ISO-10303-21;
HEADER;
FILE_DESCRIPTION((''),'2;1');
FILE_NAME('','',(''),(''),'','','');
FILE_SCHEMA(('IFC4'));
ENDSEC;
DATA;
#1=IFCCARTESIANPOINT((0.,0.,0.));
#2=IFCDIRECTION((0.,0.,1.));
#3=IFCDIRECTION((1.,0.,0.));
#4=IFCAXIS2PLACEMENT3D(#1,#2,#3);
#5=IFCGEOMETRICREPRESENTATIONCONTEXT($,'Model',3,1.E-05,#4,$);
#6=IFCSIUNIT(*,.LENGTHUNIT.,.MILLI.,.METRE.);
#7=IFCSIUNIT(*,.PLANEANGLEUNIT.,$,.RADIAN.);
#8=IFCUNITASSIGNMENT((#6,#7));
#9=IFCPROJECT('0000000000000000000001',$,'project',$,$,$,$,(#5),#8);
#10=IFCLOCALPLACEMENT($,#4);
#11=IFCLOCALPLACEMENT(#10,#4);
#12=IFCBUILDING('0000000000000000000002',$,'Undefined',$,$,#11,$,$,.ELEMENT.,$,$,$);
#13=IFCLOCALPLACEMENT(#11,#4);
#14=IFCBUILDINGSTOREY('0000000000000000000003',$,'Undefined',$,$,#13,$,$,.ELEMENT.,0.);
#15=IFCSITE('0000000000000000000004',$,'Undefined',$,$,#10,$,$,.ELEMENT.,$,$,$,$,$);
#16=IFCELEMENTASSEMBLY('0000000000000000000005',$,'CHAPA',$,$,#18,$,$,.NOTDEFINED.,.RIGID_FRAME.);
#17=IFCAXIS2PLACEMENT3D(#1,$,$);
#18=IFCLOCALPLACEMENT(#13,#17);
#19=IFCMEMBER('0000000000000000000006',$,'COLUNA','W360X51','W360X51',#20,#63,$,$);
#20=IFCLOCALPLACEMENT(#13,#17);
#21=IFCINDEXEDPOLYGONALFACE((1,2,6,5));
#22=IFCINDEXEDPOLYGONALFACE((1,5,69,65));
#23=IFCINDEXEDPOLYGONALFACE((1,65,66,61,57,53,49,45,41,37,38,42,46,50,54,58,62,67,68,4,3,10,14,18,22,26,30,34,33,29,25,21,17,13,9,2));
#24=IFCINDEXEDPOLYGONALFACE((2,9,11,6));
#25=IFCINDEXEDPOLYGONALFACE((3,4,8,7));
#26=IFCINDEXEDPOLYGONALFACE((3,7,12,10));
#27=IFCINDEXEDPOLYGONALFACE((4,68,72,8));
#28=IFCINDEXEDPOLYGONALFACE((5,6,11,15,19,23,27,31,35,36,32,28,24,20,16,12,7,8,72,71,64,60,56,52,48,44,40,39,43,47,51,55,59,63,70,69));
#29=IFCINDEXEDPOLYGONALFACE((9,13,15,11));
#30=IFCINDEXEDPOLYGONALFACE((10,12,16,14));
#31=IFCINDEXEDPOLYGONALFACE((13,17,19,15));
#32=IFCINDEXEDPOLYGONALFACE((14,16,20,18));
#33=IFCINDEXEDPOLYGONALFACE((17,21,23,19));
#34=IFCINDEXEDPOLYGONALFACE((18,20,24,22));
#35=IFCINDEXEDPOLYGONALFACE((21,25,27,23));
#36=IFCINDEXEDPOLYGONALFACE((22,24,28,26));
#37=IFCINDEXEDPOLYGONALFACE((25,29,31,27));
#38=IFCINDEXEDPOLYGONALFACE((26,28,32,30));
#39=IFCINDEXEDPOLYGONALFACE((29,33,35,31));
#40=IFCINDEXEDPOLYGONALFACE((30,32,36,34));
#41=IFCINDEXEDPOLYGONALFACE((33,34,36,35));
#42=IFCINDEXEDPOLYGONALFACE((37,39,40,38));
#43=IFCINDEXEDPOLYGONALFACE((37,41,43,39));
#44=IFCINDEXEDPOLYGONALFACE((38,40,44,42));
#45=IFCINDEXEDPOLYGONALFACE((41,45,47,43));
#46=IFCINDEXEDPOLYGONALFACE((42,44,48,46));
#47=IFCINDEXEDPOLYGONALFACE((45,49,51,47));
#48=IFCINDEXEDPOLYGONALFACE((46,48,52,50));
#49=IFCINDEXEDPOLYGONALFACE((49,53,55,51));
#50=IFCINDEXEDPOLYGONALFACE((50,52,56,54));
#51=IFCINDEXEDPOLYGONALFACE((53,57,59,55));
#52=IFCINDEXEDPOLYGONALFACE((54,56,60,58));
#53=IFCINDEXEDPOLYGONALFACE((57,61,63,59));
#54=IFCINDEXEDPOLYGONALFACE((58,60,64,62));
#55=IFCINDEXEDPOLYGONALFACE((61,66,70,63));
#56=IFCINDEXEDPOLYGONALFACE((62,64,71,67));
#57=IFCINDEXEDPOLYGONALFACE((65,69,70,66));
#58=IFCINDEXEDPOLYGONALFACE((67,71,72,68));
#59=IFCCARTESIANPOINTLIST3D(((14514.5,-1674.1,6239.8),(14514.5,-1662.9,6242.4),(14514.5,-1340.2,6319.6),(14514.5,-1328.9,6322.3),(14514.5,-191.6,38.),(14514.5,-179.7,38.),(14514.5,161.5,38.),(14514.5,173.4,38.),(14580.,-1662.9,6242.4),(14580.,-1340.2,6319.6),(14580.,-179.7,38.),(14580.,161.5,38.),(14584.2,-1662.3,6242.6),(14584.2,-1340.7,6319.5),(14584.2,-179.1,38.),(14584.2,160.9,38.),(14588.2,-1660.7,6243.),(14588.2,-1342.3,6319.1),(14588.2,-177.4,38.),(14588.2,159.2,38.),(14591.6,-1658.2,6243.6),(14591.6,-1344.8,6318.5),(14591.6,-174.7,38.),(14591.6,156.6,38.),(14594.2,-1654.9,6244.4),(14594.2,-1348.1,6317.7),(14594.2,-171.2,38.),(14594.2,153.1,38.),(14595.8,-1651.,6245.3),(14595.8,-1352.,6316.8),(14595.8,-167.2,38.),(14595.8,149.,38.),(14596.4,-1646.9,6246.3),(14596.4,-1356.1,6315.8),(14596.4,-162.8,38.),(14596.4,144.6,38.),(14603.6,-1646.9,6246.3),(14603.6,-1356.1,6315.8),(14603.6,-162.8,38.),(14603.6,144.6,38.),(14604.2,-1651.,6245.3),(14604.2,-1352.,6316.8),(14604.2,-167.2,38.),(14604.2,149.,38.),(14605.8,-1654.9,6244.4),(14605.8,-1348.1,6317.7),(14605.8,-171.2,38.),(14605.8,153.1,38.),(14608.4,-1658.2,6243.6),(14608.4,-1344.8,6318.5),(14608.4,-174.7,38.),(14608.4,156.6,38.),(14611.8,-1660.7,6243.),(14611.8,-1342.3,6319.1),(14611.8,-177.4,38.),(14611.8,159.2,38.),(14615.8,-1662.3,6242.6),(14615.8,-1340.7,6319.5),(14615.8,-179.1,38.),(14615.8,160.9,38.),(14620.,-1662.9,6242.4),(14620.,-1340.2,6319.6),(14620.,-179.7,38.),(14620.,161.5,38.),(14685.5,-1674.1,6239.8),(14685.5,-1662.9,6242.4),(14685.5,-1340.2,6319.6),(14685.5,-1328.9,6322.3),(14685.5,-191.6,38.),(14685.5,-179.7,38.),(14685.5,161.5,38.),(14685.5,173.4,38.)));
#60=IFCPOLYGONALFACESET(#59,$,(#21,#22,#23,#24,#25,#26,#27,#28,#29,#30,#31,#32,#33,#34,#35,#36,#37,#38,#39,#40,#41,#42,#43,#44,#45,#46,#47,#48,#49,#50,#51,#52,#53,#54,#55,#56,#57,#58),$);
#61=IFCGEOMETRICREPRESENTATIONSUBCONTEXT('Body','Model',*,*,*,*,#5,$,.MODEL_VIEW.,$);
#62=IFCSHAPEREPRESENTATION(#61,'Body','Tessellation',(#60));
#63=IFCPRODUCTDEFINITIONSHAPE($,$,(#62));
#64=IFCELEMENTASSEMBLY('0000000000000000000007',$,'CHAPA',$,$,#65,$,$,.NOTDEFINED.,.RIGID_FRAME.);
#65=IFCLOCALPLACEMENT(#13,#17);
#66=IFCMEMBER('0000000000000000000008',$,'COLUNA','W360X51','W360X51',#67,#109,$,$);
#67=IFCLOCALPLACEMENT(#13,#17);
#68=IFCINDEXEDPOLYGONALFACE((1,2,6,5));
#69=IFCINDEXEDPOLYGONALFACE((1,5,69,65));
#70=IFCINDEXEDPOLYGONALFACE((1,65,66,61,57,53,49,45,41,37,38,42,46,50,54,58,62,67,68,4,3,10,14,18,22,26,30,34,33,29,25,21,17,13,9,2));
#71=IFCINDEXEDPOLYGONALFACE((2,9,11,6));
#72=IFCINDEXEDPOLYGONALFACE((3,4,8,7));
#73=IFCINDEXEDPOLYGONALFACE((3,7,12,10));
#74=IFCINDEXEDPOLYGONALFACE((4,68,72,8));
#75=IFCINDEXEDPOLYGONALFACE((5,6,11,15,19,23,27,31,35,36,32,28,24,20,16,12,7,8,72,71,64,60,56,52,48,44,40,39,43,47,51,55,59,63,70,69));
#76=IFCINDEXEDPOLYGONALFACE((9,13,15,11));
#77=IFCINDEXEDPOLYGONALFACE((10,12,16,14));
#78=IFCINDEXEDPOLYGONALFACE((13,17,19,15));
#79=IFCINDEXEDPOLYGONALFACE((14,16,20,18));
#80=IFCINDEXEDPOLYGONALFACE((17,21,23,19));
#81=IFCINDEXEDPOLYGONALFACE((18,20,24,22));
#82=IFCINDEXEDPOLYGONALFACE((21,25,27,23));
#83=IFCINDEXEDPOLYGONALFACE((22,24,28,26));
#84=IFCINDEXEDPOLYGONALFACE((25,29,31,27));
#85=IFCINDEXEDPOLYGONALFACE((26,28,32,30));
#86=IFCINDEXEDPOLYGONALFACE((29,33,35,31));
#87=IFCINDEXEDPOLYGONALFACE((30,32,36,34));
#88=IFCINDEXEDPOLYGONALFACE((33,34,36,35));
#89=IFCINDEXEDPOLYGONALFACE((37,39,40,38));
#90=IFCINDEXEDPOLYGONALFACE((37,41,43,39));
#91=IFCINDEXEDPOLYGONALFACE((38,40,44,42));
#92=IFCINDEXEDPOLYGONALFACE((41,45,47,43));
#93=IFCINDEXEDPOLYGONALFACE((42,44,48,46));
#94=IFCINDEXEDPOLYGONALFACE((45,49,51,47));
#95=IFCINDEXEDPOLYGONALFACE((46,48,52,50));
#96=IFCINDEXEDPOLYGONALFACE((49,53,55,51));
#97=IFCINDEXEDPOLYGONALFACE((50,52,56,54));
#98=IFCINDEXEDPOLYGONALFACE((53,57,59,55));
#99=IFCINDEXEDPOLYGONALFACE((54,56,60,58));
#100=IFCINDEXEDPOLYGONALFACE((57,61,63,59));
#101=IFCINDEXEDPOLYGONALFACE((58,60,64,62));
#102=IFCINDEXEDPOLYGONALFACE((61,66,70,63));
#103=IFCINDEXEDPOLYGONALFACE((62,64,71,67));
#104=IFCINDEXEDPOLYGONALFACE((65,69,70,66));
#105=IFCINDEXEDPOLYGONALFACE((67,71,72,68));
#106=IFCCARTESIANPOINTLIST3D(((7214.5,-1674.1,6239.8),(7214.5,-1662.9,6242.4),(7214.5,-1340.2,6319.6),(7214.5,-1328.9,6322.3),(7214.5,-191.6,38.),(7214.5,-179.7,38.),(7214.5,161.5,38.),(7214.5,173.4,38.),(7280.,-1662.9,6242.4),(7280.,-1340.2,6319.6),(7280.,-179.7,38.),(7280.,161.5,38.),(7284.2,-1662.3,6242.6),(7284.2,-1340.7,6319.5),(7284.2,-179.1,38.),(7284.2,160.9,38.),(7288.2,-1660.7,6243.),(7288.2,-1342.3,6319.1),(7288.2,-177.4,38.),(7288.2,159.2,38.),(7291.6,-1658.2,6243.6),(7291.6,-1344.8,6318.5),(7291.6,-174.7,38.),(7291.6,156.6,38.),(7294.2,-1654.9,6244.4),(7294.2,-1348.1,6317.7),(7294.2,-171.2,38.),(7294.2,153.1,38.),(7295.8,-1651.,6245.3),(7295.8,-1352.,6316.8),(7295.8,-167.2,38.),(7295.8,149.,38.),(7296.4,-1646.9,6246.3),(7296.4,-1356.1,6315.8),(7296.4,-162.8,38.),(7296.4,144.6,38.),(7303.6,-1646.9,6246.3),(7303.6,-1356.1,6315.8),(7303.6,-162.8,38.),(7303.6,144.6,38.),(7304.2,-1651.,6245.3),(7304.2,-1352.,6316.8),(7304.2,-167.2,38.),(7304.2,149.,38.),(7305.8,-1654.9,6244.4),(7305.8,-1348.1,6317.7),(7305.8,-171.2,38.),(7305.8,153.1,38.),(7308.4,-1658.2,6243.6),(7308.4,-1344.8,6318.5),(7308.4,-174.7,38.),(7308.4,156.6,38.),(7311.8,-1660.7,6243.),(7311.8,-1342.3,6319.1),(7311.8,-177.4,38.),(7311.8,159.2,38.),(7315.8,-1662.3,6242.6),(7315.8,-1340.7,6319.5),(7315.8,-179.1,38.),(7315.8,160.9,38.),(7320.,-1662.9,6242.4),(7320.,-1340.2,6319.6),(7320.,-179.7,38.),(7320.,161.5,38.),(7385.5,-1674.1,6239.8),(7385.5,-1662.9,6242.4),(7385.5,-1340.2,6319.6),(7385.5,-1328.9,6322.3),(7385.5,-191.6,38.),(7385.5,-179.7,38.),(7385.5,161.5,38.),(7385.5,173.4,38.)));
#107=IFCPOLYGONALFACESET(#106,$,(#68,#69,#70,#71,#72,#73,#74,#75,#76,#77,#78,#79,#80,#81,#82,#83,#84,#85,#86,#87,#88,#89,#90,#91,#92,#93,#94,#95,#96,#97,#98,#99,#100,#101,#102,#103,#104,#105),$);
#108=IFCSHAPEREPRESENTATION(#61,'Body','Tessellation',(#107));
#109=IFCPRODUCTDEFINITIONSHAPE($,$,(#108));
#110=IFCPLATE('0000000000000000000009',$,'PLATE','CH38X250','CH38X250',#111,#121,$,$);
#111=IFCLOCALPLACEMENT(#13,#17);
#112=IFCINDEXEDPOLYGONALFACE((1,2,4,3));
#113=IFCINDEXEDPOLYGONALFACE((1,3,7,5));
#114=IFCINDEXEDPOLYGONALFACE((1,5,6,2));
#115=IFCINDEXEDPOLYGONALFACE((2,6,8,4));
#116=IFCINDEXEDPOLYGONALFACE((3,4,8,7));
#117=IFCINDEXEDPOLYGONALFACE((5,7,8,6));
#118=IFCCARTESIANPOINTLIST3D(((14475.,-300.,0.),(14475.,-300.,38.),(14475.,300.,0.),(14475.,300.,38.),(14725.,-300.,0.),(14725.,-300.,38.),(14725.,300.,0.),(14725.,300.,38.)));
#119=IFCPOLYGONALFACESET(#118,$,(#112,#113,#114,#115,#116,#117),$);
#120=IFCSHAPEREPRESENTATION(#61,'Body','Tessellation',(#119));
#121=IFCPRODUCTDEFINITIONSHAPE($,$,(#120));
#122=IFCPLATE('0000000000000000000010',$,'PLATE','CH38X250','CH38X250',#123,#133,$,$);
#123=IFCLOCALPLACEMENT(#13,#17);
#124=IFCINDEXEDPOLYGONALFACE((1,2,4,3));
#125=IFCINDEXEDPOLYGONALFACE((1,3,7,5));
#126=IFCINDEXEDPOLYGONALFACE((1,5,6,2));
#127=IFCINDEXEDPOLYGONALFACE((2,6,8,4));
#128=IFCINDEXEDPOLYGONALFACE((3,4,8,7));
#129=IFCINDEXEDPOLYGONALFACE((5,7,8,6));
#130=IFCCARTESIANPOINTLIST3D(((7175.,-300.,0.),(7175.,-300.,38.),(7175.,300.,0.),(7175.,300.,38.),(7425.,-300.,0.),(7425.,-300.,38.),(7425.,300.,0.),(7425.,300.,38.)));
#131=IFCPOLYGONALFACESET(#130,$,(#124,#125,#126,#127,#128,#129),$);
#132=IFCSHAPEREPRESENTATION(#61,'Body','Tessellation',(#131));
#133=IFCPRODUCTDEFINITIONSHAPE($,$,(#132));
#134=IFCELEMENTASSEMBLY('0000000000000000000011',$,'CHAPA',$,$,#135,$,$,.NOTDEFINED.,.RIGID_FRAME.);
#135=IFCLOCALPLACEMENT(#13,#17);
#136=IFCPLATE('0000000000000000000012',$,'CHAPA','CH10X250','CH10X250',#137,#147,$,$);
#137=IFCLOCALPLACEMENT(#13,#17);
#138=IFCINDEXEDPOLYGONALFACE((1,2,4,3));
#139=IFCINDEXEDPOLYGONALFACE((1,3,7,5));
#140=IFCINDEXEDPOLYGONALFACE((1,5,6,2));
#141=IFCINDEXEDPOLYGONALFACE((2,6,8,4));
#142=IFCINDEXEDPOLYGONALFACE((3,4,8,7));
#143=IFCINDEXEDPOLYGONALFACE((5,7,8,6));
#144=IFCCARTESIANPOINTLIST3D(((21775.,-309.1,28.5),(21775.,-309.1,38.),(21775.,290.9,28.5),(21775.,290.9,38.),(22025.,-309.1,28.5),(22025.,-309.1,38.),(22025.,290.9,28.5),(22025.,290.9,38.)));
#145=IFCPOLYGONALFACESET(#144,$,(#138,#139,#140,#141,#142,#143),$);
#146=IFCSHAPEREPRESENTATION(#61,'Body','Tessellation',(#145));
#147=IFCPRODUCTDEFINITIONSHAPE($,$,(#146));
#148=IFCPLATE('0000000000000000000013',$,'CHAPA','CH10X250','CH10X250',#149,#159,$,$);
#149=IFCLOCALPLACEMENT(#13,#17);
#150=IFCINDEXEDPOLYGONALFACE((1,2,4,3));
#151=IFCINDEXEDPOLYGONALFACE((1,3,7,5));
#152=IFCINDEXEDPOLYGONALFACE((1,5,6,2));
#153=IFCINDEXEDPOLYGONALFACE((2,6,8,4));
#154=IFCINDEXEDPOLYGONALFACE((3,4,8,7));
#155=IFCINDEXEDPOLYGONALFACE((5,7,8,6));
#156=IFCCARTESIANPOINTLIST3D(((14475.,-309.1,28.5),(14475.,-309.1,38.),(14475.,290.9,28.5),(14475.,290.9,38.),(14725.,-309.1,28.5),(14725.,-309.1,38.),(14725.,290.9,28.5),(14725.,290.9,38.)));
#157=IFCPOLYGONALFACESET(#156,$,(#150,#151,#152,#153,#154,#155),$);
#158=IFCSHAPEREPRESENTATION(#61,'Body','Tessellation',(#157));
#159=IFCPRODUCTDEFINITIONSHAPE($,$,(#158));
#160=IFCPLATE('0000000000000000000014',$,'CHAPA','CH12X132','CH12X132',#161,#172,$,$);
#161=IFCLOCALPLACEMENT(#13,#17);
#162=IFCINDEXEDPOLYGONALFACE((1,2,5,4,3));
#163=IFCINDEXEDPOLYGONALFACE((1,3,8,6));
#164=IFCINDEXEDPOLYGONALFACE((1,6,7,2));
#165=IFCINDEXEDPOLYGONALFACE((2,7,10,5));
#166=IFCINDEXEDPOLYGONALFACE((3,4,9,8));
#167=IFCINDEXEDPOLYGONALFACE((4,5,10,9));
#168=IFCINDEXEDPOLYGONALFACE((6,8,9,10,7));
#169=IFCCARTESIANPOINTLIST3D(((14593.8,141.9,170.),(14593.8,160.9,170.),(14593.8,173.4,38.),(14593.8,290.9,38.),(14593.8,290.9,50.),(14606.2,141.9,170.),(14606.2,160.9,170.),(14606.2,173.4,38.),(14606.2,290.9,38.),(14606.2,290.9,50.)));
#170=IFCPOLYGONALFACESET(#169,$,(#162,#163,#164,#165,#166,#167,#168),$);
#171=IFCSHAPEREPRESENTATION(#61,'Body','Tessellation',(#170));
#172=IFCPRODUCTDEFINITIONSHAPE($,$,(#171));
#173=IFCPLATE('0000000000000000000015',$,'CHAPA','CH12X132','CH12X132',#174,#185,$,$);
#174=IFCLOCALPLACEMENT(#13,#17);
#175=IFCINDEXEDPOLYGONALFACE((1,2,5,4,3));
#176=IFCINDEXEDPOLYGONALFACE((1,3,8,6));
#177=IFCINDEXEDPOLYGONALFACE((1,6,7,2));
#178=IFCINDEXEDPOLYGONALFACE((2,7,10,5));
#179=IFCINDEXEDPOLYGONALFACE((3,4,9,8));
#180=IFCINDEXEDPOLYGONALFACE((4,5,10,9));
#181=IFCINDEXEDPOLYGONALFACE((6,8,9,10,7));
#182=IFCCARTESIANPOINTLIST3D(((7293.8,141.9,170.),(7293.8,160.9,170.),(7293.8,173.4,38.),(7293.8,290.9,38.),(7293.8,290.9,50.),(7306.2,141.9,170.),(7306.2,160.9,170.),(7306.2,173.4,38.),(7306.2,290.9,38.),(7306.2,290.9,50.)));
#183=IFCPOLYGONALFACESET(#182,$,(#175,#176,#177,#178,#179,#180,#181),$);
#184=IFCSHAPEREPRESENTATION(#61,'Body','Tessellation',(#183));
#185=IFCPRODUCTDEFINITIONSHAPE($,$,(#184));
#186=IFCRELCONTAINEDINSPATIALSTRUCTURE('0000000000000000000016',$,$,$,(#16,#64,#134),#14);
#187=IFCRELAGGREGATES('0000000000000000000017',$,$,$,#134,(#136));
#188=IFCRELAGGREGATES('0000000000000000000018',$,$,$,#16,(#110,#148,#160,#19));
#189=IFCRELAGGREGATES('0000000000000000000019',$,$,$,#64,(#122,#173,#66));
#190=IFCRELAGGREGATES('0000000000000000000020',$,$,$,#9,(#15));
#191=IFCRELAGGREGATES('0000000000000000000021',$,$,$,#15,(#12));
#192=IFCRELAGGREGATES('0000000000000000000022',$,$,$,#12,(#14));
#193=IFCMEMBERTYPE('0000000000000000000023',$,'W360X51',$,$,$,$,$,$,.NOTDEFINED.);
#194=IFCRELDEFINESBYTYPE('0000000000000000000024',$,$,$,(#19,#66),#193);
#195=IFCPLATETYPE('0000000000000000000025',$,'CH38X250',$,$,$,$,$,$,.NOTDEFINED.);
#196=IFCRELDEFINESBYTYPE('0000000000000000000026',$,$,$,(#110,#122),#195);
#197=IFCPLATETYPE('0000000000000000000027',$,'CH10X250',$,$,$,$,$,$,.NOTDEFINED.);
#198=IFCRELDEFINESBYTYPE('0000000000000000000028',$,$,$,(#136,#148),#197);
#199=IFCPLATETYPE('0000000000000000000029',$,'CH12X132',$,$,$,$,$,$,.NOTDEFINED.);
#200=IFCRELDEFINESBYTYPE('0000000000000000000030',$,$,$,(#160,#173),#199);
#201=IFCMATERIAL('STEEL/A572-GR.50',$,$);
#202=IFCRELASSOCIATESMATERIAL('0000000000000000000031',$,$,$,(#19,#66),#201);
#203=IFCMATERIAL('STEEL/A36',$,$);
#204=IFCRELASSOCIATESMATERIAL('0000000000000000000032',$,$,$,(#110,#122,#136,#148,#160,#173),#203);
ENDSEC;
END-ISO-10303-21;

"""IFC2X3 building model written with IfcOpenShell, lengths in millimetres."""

from ifc_helpers import new_model, si_unit, frame, origin_with_axes, origin_2d_with_axis, place, context, subcontext, project, spatial, polyline, i_section, outline, extrude, clip, halfspace, material, type_object, element, aggregate, save


model = new_model("IFC2X3")

# Units and contexts
model_context = context("Model", 3, precision=1e-05, world=origin_with_axes())
body_context = subcontext(model_context, "Body", "Model", "MODEL_VIEW")
ifc_project = project(units=[si_unit("LENGTHUNIT", "METRE", prefix="MILLI"), si_unit("PLANEANGLEUNIT", "RADIAN")], contexts=[model_context])

# Site, building, storey
site_placement = place(None, origin_with_axes())
site = spatial("IfcSite", under=ifc_project, at=site_placement, Name="Undefined", CompositionType="ELEMENT")
building_placement = place(site_placement, origin_with_axes())
building = spatial("IfcBuilding", under=site, at=building_placement, Name="Undefined", CompositionType="ELEMENT")
storey_placement = place(building_placement, origin_with_axes())
storey = spatial("IfcBuildingStorey", under=building, at=storey_placement, Name="Undefined", CompositionType="ELEMENT", Elevation=0.0)

# Element assemblies, members
assembly_1_placement = place(storey_placement, origin_with_axes())
assembly_1 = element("IfcElementAssembly", 1, at=assembly_1_placement, inside=storey, Name="CHAPA", AssemblyPlace="NOTDEFINED", PredefinedType="RIGID_FRAME")
ifc_material_1 = material(Name="STEEL/A572-GR.50")
member_type = type_object("IfcMemberType", Name="W360X51", PredefinedType="NOTDEFINED")
member_1_placement = place(assembly_1_placement, frame((14600.0, 23.3, -97.3), z_axis=(0.0, -0.972595, -0.232504), x_axis=(0.0, -0.232504, 0.972595)))
member_1 = element("IfcMember", 2, at=member_1_placement, type_object=member_type, material=ifc_material_1, Name="COLUNA", Description="W360X51", ObjectType="W360X51", context=body_context, shape_type="Clipping", body=[
    clip(clip(extrude(i_section(OverallWidth=171.0, OverallDepth=355.0, WebThickness=7.2, FlangeThickness=11.6, FilletRadius=16.4, at=origin_2d_with_axis()), frame((6558.0, 0.0, 0.0), z_axis=(-1.0, 0.0, 0.0), x_axis=(0.0, -1.0, 0.0)), (0.0, 0.0, 1.0), 6542.9), halfspace(frame((94.5, 85.5, -186.3), z_axis=(-0.972595, 0.0, 0.232504), x_axis=(0.232504, 0.0, 0.972595)), False)), halfspace(frame((96.6, 0.0, -177.5), z_axis=(0.972595, 0.0, -0.232504), x_axis=(0.0, -1.0, 0.0)), True)),
])
assembly_2_placement = place(storey_placement, origin_with_axes())
assembly_2 = element("IfcElementAssembly", 3, at=assembly_2_placement, inside=storey, Name="CHAPA", AssemblyPlace="NOTDEFINED", PredefinedType="RIGID_FRAME")
member_2_placement = place(assembly_2_placement, frame((7300.0, 23.3, -97.3), z_axis=(0.0, -0.972595, -0.232504), x_axis=(0.0, -0.232504, 0.972595)))
member_2 = element("IfcMember", 4, at=member_2_placement, type_object=member_type, material=ifc_material_1, Name="COLUNA", Description="W360X51", ObjectType="W360X51", context=body_context, shape_type="Clipping", body=[
    clip(clip(extrude(i_section(OverallWidth=171.0, OverallDepth=355.0, WebThickness=7.2, FlangeThickness=11.6, FilletRadius=16.4, at=origin_2d_with_axis()), frame((6558.0, 0.0, 0.0), z_axis=(-1.0, 0.0, 0.0), x_axis=(0.0, -1.0, 0.0)), (0.0, 0.0, 1.0), 6542.9), halfspace(frame((94.5, 85.5, -186.3), z_axis=(-0.972595, 0.0, 0.232504), x_axis=(0.232504, 0.0, 0.972595)), False)), halfspace(frame((96.6, 0.0, -177.5), z_axis=(0.972595, 0.0, -0.232504), x_axis=(0.0, -1.0, 0.0)), True)),
])

# Plates
ifc_material_2 = material(Name="STEEL/A36")
plate_type_1 = type_object("IfcPlateType", Name="CH38X250", PredefinedType="NOTDEFINED")
plate_1_placement = place(assembly_1_placement, frame((14725.0, -300.0, 19.0), z_axis=(0.0, 0.0, 1.0), x_axis=(0.0, 1.0, 0.0)))
plate_1 = element("IfcPlate", 5, at=plate_1_placement, type_object=plate_type_1, material=ifc_material_2, Name="PLATE", Description="CH38X250", ObjectType="CH38X250", context=body_context, shape_type="SweptSolid", body=[
    extrude(outline(polyline([(0.0, 0.0), (600.0, 0.0), (600.0, 250.0), (0.0, 250.0), (0.0, 0.0)])), frame((0.0, 0.0, -19.0), z_axis=(0.0, 0.0, 1.0), x_axis=(1.0, 0.0, 0.0)), (0.0, 0.0, 1.0), 38.0),
])
plate_2_placement = place(assembly_2_placement, frame((7425.0, -300.0, 19.0), z_axis=(0.0, 0.0, 1.0), x_axis=(0.0, 1.0, 0.0)))
plate_2 = element("IfcPlate", 6, at=plate_2_placement, type_object=plate_type_1, material=ifc_material_2, Name="PLATE", Description="CH38X250", ObjectType="CH38X250", context=body_context, shape_type="SweptSolid", body=[
    extrude(outline(polyline([(0.0, 0.0), (600.0, 0.0), (600.0, 250.0), (0.0, 250.0), (0.0, 0.0)])), frame((0.0, 0.0, -19.0), z_axis=(0.0, 0.0, 1.0), x_axis=(1.0, 0.0, 0.0)), (0.0, 0.0, 1.0), 38.0),
])

# Element assembly, plate
assembly_3_placement = place(storey_placement, origin_with_axes())
assembly_3 = element("IfcElementAssembly", 7, at=assembly_3_placement, inside=storey, Name="CHAPA", AssemblyPlace="NOTDEFINED", PredefinedType="RIGID_FRAME")
plate_type_2 = type_object("IfcPlateType", Name="CH10X250", PredefinedType="NOTDEFINED")
plate_3_placement = place(assembly_3_placement, frame((21775.0, -309.1, 33.2), z_axis=(0.0, 0.0, 1.0), x_axis=(1.0, 0.0, 0.0)))
plate_3 = element("IfcPlate", 8, at=plate_3_placement, type_object=plate_type_2, material=ifc_material_2, Name="CHAPA", Description="CH10X250", ObjectType="CH10X250", context=body_context, shape_type="SweptSolid", body=[
    extrude(outline(polyline([(0.0, 0.0), (250.0, 0.0), (250.0, 600.0), (0.0, 600.0), (0.0, 0.0)])), frame((0.0, 0.0, -4.8), z_axis=(0.0, 0.0, 1.0), x_axis=(1.0, 0.0, 0.0)), (0.0, 0.0, 1.0), 9.5),
])
aggregate(assembly_3, [plate_3])

# Plates
plate_4_placement = place(assembly_1_placement, frame((14475.0, -309.1, 33.2), z_axis=(0.0, 0.0, 1.0), x_axis=(1.0, 0.0, 0.0)))
plate_4 = element("IfcPlate", 9, at=plate_4_placement, type_object=plate_type_2, material=ifc_material_2, Name="CHAPA", Description="CH10X250", ObjectType="CH10X250", context=body_context, shape_type="SweptSolid", body=[
    extrude(outline(polyline([(0.0, 0.0), (250.0, 0.0), (250.0, 600.0), (0.0, 600.0), (0.0, 0.0)])), frame((0.0, 0.0, -4.8), z_axis=(0.0, 0.0, 1.0), x_axis=(1.0, 0.0, 0.0)), (0.0, 0.0, 1.0), 9.5),
])
plate_type_3 = type_object("IfcPlateType", Name="CH12X132", PredefinedType="NOTDEFINED")
plate_5_placement = place(assembly_1_placement, frame((14600.0, 173.4, 38.0), z_axis=(1.0, 0.0, 0.0), x_axis=(0.0, 1.0, 0.0)))
plate_5 = element("IfcPlate", 10, at=plate_5_placement, type_object=plate_type_3, material=ifc_material_2, Name="CHAPA", Description="CH12X132", ObjectType="CH12X132", context=body_context, shape_type="SweptSolid", body=[
    extrude(outline(polyline([(0.0, 0.0), (117.5, 0.0), (117.5, 12.0), (-12.5, 132.0), (-31.6, 132.0), (0.0, 0.0)])), frame((0.0, 0.0, -6.2), z_axis=(0.0, 0.0, 1.0), x_axis=(1.0, 0.0, 0.0)), (0.0, 0.0, 1.0), 12.5),
])
plate_6_placement = place(assembly_2_placement, frame((7300.0, 173.4, 38.0), z_axis=(1.0, 0.0, 0.0), x_axis=(0.0, 1.0, 0.0)))
plate_6 = element("IfcPlate", 11, at=plate_6_placement, type_object=plate_type_3, material=ifc_material_2, Name="CHAPA", Description="CH12X132", ObjectType="CH12X132", context=body_context, shape_type="SweptSolid", body=[
    extrude(outline(polyline([(0.0, 0.0), (117.5, 0.0), (117.5, 12.0), (-12.5, 132.0), (-31.6, 132.0), (0.0, 0.0)])), frame((0.0, 0.0, -6.2), z_axis=(0.0, 0.0, 1.0), x_axis=(1.0, 0.0, 0.0)), (0.0, 0.0, 1.0), 12.5),
])

aggregate(assembly_1, [plate_1, plate_4, plate_5, member_1])
aggregate(assembly_2, [plate_2, plate_6, member_2])

save(model, "model.ifc")
